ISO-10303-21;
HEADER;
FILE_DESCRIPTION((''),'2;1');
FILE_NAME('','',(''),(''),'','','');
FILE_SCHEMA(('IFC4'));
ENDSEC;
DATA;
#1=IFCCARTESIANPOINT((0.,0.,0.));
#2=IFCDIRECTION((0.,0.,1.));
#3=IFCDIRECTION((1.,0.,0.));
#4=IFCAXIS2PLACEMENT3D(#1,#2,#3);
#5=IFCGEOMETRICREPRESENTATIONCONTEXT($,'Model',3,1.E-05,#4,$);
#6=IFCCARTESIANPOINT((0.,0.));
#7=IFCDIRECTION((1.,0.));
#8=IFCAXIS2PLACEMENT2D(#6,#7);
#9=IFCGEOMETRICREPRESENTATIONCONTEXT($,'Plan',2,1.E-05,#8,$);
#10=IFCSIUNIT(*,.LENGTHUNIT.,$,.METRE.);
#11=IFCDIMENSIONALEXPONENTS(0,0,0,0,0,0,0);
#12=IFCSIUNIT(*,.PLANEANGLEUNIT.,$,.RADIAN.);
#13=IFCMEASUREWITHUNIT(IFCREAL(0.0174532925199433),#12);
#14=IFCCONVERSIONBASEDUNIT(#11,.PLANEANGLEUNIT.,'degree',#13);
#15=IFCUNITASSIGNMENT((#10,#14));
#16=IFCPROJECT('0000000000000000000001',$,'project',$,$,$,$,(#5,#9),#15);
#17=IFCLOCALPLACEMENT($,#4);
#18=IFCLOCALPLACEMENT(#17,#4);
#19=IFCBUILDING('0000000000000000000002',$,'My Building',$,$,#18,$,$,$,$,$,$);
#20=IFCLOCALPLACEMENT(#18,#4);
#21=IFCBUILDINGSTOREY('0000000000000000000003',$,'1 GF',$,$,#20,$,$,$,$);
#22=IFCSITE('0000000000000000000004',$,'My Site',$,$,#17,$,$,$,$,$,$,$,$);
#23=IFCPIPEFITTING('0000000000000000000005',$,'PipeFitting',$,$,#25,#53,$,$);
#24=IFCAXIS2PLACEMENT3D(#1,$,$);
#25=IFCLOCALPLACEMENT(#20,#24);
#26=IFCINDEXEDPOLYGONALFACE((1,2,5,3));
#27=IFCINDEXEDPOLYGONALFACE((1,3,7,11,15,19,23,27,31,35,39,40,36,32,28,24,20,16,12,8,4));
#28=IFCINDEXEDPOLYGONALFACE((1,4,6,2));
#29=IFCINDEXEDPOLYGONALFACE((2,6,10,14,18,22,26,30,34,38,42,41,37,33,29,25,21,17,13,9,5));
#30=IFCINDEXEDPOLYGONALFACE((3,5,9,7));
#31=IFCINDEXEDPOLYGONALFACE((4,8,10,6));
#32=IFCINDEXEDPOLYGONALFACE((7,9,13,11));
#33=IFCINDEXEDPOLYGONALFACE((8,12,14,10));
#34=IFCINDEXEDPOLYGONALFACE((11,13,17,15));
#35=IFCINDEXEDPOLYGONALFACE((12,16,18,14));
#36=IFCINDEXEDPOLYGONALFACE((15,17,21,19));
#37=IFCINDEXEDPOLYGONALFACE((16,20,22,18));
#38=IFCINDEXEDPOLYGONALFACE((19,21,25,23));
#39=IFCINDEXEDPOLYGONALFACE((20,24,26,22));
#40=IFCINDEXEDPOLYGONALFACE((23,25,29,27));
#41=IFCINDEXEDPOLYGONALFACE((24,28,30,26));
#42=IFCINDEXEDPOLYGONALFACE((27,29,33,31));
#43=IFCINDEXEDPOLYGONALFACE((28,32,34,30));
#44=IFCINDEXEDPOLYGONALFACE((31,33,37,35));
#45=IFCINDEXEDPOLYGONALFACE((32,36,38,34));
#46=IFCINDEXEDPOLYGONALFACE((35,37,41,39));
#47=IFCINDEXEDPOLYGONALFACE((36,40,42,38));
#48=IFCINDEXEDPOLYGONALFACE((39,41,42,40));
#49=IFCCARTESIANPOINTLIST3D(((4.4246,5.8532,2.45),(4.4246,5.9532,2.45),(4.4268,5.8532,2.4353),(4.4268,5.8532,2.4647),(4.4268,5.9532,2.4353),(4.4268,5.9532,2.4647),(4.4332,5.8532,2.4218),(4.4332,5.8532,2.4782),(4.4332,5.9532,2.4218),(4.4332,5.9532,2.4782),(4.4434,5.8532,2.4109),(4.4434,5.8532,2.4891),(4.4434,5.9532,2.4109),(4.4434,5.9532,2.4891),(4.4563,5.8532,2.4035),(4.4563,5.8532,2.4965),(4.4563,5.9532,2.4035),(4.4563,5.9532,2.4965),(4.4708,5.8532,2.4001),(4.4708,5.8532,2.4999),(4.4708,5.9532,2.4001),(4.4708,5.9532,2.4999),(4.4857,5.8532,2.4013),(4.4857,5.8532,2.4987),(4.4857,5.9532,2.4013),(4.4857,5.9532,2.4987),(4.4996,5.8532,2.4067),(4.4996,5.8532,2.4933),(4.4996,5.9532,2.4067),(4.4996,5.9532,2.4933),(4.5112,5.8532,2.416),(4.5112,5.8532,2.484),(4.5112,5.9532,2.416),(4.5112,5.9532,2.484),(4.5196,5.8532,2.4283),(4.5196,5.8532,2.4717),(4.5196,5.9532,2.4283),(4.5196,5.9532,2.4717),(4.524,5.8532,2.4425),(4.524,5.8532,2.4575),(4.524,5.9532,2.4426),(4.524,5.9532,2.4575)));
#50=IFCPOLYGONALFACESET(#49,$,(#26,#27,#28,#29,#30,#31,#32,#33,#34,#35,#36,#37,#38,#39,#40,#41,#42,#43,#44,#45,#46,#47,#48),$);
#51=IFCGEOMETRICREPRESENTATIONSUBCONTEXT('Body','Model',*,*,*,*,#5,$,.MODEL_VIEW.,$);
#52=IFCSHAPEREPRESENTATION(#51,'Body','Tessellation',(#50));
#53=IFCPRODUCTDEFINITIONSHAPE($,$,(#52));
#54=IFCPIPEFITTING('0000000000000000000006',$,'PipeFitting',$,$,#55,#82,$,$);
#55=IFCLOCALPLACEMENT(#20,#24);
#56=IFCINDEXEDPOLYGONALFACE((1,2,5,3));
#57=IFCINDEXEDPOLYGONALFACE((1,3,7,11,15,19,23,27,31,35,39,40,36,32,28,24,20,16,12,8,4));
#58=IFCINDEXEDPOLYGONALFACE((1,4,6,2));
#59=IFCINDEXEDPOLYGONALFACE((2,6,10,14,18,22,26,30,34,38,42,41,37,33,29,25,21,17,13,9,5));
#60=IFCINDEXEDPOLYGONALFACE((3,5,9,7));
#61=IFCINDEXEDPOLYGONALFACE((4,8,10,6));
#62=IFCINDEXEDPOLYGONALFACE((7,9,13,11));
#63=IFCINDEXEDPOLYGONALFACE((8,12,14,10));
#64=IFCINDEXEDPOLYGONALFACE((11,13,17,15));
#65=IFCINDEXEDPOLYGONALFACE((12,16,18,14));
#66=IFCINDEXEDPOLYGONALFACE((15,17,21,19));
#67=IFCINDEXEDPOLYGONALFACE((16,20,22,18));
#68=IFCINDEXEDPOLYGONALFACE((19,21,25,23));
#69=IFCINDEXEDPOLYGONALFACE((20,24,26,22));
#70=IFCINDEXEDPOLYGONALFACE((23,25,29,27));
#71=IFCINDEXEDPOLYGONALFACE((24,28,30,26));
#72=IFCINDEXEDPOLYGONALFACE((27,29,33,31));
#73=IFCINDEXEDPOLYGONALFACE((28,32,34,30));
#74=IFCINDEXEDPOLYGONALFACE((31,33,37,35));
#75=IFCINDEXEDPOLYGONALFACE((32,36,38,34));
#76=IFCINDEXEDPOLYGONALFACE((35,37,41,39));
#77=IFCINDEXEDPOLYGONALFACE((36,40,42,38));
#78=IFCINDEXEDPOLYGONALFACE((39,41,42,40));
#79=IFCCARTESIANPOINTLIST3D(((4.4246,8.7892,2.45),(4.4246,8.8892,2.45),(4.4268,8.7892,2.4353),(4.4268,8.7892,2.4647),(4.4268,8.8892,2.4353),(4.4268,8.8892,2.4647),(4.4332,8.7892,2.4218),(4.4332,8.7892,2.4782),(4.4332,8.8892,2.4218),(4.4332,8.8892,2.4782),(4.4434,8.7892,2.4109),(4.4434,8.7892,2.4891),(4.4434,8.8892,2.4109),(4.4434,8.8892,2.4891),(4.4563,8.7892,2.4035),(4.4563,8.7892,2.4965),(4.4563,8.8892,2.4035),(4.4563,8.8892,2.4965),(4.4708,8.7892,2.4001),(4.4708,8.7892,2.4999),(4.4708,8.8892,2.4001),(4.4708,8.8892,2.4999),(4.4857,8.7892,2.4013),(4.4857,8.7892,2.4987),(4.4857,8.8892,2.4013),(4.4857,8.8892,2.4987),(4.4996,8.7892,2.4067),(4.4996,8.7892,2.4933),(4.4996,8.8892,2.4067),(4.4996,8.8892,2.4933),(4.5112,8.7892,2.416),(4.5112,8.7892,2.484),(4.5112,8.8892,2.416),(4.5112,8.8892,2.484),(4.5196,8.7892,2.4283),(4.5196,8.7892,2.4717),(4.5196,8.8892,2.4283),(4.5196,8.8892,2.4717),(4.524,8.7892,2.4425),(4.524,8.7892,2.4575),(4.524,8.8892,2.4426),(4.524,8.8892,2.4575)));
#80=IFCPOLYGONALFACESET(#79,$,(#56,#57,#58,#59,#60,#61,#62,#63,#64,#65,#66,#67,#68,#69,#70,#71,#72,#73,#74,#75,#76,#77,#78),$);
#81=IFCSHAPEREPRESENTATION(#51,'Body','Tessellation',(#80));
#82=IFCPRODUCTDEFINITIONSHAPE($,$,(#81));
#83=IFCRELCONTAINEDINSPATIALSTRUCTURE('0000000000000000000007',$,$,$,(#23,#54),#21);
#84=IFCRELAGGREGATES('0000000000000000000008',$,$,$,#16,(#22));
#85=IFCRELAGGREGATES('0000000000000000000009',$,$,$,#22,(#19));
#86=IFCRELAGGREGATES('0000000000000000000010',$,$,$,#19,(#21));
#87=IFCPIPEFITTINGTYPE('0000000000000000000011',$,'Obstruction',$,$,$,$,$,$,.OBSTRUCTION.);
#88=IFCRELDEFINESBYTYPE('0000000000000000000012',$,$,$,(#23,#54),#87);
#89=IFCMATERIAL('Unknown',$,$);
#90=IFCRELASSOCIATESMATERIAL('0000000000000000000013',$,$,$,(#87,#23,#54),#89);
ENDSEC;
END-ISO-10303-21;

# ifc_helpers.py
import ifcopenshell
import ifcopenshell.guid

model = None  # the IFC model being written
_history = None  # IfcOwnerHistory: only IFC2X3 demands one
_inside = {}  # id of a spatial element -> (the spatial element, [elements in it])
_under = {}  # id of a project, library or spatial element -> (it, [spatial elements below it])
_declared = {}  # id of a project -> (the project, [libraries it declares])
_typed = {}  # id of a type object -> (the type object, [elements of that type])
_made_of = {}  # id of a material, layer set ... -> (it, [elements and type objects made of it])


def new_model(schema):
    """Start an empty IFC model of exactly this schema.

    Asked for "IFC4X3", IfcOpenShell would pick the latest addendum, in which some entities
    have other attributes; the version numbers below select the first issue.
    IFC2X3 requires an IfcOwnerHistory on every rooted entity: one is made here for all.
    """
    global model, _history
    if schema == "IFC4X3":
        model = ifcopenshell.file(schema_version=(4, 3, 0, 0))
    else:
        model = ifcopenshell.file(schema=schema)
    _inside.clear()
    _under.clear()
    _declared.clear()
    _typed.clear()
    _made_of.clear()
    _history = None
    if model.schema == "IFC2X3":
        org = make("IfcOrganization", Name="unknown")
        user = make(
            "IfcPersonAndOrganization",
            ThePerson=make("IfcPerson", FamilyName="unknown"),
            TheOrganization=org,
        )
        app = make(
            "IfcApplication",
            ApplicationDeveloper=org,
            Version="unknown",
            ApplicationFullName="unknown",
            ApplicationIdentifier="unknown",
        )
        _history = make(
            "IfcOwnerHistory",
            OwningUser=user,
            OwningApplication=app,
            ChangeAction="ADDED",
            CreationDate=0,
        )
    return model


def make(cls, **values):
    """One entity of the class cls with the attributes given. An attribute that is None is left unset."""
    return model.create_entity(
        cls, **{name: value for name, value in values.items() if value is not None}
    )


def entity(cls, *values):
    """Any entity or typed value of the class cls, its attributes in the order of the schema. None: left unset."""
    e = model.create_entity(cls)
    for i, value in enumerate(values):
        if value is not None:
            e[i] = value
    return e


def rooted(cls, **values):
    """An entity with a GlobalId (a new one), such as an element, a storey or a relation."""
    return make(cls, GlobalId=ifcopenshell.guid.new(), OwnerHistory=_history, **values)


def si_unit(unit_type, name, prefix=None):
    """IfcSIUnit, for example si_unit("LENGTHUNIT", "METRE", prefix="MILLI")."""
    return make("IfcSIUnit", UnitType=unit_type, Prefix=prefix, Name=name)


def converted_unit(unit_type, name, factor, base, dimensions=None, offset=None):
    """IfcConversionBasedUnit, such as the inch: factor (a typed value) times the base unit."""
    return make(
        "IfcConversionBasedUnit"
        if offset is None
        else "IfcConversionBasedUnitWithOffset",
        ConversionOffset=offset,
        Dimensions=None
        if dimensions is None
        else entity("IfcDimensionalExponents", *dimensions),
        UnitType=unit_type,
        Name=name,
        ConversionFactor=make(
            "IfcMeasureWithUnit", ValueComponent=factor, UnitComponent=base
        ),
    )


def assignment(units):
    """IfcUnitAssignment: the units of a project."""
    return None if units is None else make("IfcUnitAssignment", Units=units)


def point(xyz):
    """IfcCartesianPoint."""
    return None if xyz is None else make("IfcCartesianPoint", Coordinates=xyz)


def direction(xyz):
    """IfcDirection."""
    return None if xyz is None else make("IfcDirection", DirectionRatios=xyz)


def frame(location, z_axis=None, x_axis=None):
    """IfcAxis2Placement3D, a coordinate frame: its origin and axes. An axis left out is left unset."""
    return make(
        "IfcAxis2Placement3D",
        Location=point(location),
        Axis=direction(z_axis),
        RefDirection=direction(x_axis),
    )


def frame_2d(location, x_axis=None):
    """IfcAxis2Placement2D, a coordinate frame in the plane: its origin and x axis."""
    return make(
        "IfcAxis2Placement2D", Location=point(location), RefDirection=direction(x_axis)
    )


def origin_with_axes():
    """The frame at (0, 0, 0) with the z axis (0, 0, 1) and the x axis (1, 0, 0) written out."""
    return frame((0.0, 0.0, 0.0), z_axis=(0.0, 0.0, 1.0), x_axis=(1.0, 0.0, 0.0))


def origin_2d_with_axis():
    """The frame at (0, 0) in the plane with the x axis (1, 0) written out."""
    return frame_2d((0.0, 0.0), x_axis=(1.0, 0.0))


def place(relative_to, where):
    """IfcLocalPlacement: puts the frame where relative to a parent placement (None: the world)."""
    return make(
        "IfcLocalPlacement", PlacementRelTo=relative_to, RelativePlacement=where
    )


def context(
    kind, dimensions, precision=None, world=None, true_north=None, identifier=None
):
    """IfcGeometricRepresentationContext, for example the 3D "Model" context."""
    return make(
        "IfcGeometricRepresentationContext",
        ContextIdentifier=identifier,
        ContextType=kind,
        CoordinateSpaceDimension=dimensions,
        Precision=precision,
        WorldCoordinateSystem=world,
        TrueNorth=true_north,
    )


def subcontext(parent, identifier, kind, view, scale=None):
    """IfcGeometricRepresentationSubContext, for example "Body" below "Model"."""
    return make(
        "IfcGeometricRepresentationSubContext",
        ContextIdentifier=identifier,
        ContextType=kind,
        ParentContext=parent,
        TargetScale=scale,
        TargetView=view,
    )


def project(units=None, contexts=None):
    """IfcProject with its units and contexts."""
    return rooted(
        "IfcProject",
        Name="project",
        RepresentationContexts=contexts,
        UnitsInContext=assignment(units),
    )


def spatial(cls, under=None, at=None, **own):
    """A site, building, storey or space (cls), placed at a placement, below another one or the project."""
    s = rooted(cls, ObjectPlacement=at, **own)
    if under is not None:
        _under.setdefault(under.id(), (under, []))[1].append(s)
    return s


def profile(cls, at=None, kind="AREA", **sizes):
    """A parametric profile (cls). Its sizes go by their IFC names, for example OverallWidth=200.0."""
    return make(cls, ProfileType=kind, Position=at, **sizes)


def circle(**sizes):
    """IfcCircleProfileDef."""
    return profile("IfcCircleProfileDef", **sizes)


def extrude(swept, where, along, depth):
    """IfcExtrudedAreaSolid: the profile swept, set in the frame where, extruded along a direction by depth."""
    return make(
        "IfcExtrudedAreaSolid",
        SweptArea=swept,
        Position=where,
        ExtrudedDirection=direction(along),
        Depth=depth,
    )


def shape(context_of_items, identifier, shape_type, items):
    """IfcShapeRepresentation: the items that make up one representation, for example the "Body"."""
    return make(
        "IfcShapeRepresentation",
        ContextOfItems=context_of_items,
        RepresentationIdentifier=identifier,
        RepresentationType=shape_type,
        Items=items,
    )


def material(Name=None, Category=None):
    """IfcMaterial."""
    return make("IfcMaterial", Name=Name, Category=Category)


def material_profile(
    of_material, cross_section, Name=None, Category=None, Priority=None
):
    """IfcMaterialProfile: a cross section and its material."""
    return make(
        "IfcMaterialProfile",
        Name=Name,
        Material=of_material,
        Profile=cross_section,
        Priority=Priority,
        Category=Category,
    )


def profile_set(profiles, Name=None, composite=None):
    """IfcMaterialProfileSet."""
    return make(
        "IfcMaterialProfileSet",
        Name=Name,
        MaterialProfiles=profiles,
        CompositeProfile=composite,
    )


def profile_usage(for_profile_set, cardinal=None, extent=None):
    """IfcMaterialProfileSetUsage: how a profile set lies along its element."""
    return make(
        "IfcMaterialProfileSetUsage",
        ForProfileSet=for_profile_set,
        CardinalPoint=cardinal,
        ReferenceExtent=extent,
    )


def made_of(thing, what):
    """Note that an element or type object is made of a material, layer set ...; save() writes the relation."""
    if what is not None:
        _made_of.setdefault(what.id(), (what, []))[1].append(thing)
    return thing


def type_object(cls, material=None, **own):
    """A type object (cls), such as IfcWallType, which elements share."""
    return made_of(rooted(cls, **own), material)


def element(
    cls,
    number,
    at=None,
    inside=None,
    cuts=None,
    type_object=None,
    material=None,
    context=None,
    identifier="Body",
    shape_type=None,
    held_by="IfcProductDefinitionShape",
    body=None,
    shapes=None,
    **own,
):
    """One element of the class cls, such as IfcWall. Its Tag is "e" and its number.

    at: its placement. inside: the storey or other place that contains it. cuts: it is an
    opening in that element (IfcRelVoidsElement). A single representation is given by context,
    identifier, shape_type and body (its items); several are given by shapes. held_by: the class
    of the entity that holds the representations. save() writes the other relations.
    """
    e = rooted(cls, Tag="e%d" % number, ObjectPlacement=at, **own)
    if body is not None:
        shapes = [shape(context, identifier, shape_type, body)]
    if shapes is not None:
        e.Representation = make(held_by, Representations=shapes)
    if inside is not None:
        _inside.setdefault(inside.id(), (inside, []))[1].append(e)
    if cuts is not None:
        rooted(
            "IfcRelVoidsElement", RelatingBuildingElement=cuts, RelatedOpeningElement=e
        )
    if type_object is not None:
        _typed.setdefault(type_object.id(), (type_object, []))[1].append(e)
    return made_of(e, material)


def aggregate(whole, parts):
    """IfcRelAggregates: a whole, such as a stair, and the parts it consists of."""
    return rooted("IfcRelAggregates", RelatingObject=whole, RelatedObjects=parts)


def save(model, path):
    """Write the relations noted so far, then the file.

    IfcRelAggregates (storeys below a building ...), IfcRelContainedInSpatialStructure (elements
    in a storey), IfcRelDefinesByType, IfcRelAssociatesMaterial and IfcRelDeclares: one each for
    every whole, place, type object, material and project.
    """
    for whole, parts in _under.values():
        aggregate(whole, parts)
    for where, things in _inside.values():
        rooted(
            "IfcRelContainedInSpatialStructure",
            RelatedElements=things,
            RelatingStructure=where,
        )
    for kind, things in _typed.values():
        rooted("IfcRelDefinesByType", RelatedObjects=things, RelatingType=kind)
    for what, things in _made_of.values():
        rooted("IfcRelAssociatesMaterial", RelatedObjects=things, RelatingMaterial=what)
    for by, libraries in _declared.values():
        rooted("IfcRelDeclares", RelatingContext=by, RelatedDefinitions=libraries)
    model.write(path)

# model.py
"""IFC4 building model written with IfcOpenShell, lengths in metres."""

from ifc_helpers import new_model, entity, si_unit, converted_unit, frame, origin_with_axes, origin_2d_with_axis, place, context, subcontext, project, spatial, circle, extrude, material, material_profile, profile_set, profile_usage, type_object, element, save


model = new_model("IFC4")

# Units and contexts
model_context = context("Model", 3, precision=1e-05, world=origin_with_axes())
plan_context = context("Plan", 2, precision=1e-05, world=origin_2d_with_axis())
body_context_1 = subcontext(model_context, "Body", "Model", "MODEL_VIEW")
ifc_project = project(units=[si_unit("LENGTHUNIT", "METRE"), converted_unit("PLANEANGLEUNIT", "degree", entity("IfcReal", 0.0174532925199433), si_unit("PLANEANGLEUNIT", "RADIAN"), dimensions=[0, 0, 0, 0, 0, 0, 0])], contexts=[model_context, plan_context])

# Site, building, storey
site_placement = place(None, origin_with_axes())
site = spatial("IfcSite", under=ifc_project, at=site_placement, Name="My Site")
building_placement = place(site_placement, origin_with_axes())
building = spatial("IfcBuilding", under=site, at=building_placement, Name="My Building")
storey_placement = place(building_placement, origin_with_axes())
storey = spatial("IfcBuildingStorey", under=building, at=storey_placement, Name="1 GF")

# Shared definitions
ifc_material = material(Name="Unknown")

# Pipe fittings
ifc_material_profile_1 = material_profile(ifc_material, circle(Radius=0.05))
ifc_profile_set_1 = profile_set([ifc_material_profile_1])
pipe_fitting_type = type_object("IfcPipeFittingType", Name="Obstruction", PredefinedType="OBSTRUCTION", material=ifc_profile_set_1)
ifc_profile_usage_1 = profile_usage(ifc_profile_set_1, cardinal=5)
pipe_fitting_1_placement = place(storey_placement, frame((4.4746, 5.8532, 2.45), z_axis=(0.0, 1.0, 0.000025), x_axis=(-1.0, 0.0, 0.0)))
element("IfcPipeFitting", 1, at=pipe_fitting_1_placement, inside=storey, type_object=pipe_fitting_type, material=ifc_profile_usage_1, Name="PipeFitting", context=body_context_1, shape_type="SweptSolid", body=[
    extrude(circle(Radius=0.05), origin_with_axes(), (0.0, 0.0, 1.0), 0.1),
])
ifc_profile_usage_2 = profile_usage(ifc_profile_set_1, cardinal=5)
pipe_fitting_2_placement = place(storey_placement, frame((4.4746, 8.7892, 2.45), z_axis=(0.0, 1.0, 0.000025), x_axis=(-1.0, 0.0, 0.0)))
element("IfcPipeFitting", 2, at=pipe_fitting_2_placement, inside=storey, type_object=pipe_fitting_type, material=ifc_profile_usage_2, Name="PipeFitting", context=body_context_1, shape_type="SweptSolid", body=[
    extrude(circle(Radius=0.05), origin_with_axes(), (0.0, 0.0, 1.0), 0.1),
])

save(model, "model.ifc")
